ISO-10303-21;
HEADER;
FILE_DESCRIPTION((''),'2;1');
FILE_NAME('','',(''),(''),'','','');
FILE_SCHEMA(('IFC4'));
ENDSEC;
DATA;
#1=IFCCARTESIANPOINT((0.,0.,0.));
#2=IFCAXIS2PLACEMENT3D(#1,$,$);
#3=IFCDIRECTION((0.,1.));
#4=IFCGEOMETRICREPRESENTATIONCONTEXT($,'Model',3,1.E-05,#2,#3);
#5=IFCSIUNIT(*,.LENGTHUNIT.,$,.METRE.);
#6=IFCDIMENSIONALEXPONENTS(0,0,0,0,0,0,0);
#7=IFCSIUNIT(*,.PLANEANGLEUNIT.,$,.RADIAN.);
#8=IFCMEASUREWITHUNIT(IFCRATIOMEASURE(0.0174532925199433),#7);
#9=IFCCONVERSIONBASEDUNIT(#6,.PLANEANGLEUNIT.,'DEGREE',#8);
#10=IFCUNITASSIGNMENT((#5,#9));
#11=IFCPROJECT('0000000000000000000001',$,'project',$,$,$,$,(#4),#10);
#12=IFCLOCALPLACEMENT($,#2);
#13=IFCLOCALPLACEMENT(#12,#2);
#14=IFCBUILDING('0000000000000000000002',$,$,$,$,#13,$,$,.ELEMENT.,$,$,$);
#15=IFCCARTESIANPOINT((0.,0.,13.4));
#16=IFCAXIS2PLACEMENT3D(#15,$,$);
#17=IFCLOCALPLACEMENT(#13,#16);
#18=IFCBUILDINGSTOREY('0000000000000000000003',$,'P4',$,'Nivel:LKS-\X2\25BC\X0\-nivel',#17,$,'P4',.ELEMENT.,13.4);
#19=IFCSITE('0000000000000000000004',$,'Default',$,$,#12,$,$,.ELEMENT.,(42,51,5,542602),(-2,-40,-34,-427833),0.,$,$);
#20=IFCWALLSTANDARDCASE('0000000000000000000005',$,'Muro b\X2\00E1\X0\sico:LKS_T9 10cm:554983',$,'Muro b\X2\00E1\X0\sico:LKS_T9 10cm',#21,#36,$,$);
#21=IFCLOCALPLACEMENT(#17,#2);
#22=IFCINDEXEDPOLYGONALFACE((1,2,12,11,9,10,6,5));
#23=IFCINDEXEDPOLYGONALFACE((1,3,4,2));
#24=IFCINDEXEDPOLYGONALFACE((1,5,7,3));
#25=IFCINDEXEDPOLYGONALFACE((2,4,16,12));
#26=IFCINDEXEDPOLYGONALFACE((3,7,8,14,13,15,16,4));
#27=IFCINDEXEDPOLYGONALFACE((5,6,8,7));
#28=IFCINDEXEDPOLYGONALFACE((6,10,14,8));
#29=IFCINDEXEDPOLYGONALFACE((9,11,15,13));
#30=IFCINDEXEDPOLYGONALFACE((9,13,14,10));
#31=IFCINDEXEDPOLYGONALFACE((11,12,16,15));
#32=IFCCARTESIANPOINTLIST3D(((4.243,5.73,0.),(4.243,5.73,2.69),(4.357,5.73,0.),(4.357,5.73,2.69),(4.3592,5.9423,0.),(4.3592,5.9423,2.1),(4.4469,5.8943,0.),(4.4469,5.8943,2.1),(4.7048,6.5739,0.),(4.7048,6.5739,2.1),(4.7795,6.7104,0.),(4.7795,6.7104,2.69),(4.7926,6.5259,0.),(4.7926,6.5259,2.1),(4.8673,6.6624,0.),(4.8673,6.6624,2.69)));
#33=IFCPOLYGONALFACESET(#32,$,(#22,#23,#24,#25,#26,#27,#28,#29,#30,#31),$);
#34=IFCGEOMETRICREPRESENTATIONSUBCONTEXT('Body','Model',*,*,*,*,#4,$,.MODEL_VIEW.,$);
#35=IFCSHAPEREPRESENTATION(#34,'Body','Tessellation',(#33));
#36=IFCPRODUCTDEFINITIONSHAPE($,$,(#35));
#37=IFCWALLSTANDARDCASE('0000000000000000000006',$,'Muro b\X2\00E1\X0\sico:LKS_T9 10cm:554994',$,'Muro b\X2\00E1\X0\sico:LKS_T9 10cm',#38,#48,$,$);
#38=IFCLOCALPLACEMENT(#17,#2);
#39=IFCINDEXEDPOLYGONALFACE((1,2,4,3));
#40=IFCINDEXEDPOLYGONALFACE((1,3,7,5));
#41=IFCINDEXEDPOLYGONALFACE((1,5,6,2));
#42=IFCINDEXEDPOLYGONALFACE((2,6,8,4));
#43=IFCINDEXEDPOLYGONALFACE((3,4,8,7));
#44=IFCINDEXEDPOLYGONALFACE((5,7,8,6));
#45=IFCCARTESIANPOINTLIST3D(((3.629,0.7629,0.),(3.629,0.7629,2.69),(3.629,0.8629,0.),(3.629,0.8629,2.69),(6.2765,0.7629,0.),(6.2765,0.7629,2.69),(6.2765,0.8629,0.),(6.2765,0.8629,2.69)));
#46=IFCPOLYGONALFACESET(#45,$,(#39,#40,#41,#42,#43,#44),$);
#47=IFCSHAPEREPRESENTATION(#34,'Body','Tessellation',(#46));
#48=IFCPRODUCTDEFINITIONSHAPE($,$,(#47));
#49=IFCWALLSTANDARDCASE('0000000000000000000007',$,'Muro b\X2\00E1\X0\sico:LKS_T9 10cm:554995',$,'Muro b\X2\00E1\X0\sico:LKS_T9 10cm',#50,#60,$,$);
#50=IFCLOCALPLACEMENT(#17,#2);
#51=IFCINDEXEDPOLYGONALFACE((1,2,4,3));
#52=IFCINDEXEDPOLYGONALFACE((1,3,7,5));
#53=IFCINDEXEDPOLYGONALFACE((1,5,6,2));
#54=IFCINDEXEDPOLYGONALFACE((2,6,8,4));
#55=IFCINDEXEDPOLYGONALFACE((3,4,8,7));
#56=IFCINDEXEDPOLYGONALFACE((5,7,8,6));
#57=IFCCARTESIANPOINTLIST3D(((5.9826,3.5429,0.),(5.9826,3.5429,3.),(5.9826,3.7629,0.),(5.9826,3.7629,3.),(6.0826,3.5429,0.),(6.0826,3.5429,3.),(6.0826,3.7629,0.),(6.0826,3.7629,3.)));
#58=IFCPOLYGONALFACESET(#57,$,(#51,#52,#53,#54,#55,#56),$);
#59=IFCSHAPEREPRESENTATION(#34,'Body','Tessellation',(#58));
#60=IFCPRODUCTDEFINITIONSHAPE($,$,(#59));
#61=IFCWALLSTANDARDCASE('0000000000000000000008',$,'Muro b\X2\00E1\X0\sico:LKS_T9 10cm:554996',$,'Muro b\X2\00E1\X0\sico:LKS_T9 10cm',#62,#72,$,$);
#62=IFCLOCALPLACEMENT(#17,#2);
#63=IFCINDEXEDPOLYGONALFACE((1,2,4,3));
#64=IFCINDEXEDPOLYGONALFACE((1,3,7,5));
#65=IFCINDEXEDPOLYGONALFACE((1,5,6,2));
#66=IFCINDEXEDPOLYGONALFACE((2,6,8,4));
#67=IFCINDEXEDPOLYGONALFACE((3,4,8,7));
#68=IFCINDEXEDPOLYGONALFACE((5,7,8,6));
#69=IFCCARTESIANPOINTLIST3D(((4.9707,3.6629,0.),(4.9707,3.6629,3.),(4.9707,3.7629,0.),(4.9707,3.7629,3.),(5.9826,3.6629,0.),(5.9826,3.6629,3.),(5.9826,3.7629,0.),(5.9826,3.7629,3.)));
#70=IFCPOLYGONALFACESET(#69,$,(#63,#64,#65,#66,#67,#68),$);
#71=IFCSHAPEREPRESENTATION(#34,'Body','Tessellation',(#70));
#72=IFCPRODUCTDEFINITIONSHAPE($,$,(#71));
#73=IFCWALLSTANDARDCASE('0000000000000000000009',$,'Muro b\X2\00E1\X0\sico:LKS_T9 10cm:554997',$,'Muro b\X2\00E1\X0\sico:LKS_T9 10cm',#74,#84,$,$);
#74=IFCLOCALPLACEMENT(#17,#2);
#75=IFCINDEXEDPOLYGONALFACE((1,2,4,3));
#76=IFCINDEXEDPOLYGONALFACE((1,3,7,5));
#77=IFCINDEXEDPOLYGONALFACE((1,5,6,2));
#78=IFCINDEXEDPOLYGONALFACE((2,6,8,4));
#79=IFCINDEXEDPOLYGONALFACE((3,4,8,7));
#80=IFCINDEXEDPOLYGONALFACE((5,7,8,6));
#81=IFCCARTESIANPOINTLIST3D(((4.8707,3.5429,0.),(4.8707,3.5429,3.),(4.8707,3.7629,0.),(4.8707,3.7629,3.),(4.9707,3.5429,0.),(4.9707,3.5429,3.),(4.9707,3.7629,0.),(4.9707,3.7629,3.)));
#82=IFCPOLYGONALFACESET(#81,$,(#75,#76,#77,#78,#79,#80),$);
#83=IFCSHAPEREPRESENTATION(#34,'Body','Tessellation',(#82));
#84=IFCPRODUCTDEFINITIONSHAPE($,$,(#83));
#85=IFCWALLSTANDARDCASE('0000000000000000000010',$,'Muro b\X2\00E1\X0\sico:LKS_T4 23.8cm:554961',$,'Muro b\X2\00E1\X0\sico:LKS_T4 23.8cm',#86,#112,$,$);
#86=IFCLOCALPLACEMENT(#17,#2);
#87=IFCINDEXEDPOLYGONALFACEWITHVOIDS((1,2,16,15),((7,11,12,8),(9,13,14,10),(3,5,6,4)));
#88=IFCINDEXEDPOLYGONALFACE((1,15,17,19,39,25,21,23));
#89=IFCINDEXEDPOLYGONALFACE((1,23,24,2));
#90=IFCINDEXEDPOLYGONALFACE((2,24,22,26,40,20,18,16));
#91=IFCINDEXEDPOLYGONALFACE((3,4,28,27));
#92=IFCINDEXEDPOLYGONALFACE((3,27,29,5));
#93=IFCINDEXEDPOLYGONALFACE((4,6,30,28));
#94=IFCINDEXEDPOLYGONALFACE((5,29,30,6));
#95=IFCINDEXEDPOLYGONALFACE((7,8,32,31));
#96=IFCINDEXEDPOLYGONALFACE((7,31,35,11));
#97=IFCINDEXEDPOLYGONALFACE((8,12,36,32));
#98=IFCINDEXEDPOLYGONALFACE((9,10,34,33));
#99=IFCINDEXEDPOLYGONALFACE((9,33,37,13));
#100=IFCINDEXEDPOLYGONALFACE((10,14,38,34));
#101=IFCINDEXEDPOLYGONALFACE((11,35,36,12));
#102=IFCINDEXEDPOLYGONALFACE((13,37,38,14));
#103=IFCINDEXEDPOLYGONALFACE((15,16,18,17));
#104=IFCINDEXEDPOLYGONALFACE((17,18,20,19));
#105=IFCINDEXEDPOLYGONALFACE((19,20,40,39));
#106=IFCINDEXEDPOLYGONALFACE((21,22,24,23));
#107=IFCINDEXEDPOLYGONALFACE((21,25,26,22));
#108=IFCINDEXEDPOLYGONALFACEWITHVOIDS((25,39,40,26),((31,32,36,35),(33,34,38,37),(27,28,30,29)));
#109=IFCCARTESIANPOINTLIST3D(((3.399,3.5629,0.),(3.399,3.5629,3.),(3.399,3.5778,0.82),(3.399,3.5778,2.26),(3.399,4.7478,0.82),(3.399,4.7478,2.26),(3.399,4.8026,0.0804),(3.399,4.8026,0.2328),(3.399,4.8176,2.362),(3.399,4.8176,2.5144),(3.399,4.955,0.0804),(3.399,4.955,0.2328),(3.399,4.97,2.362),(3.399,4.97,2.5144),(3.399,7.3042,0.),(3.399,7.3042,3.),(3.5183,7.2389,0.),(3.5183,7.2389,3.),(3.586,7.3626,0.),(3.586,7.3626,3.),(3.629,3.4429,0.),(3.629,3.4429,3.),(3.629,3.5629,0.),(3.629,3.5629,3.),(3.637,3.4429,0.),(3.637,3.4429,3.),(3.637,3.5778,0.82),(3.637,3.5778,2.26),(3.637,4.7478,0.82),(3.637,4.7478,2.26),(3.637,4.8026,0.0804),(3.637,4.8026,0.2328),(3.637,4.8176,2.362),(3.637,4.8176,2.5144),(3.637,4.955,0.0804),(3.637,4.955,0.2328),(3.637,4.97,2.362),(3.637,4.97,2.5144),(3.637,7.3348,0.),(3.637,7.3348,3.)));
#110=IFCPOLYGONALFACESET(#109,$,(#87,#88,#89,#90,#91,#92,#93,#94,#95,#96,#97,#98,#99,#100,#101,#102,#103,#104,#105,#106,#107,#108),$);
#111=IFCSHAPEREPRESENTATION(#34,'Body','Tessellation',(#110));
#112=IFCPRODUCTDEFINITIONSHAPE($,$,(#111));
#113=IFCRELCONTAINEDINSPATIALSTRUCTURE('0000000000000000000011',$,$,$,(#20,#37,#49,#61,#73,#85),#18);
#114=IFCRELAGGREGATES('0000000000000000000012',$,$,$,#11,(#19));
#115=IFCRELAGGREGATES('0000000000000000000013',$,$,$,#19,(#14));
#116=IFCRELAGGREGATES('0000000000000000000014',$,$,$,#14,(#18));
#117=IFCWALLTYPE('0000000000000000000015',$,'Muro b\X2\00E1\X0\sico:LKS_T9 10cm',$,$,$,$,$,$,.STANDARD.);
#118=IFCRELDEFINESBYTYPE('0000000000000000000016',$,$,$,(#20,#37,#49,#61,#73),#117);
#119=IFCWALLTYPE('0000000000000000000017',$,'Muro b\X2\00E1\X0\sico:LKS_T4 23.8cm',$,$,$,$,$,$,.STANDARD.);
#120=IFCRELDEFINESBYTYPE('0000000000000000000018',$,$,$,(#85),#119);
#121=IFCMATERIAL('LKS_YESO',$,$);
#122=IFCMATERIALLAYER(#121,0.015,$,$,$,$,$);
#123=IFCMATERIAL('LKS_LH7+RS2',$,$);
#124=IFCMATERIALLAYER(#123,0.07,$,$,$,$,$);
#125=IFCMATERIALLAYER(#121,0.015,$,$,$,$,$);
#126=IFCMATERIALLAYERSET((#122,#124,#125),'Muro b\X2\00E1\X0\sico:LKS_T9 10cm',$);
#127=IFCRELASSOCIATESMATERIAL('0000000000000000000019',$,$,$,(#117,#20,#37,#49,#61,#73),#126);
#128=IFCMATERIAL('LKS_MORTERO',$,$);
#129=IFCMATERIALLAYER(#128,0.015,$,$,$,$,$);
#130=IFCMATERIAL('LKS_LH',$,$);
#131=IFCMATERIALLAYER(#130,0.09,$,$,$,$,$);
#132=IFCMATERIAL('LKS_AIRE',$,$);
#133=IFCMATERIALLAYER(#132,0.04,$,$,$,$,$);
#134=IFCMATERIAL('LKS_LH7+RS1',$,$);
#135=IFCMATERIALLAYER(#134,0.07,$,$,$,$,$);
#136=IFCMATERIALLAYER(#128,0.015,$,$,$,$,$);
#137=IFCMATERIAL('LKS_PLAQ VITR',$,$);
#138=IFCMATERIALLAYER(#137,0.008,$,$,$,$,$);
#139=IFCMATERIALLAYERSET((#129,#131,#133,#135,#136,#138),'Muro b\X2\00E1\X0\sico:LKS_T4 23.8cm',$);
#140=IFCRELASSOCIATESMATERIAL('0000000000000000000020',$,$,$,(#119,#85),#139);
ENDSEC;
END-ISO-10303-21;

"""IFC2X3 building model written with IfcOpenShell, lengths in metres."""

from ifc_helpers import new_model, entity, si_unit, converted_unit, direction, frame, frame_2d, origin, place, context, subcontext, project, spatial, polyline, rectangle, outline, extrude, clip, bounded_halfspace, material, layer, layer_set, layer_usage, type_object, element, save


model = new_model("IFC2X3")

# Units and contexts
model_context = context("Model", 3, precision=1e-05, world=origin(), true_north=direction((0.0, 1.0)))
body_context = subcontext(model_context, "Body", "Model", "MODEL_VIEW")
ifc_project = project(units=[si_unit("LENGTHUNIT", "METRE"), converted_unit("PLANEANGLEUNIT", "DEGREE", entity("IfcRatioMeasure", 0.0174532925199433), si_unit("PLANEANGLEUNIT", "RADIAN"), dimensions=[0, 0, 0, 0, 0, 0, 0])], contexts=[model_context])

# Site, building, storey
site_placement = place(None, origin())
site = spatial("IfcSite", under=ifc_project, at=site_placement, Name="Default", CompositionType="ELEMENT", RefLatitude=(42, 51, 5, 542602), RefLongitude=(-2, -40, -34, -427833), RefElevation=0.0)
building_placement = place(site_placement, origin())
building = spatial("IfcBuilding", under=site, at=building_placement, CompositionType="ELEMENT")
storey_placement = place(building_placement, frame((0.0, 0.0, 13.4)))
storey = spatial("IfcBuildingStorey", under=building, at=storey_placement, Name="P4", ObjectType="Nivel:LKS-▼-nivel", LongName="P4", CompositionType="ELEMENT", Elevation=13.4)

# Shared definitions
ifc_material_1 = material(Name="LKS_MORTERO")
ifc_material_2 = material(Name="LKS_PLAQ VITR")

# Shared definitions
ifc_material_3 = material(Name="LKS_LH")
ifc_material_4 = material(Name="LKS_AIRE")
ifc_material_5 = material(Name="LKS_LH7+RS1")
ifc_material_6 = material(Name="LKS_YESO")

# Shared definitions
ifc_layer_1 = layer(ifc_material_6, 0.015)
ifc_material_7 = material(Name="LKS_LH7+RS2")
ifc_layer_2 = layer(ifc_material_7, 0.07)
ifc_layer_3 = layer(ifc_material_6, 0.015)
ifc_layer_set_1 = layer_set([ifc_layer_1, ifc_layer_2, ifc_layer_3], Name="Muro básico:LKS_T9 10cm")
wall_type_1 = type_object("IfcWallType", Name="Muro básico:LKS_T9 10cm", PredefinedType="STANDARD", material=ifc_layer_set_1)

# Wall, opening
ifc_layer_usage_1 = layer_usage(ifc_layer_set_1, "AXIS2", "NEGATIVE", 0.05)
wall_1_placement = place(storey_placement, frame((4.2869, 5.706, 0.0), z_axis=(0.0, 0.0, 1.0), x_axis=(0.480022, 0.877256, 0.0)))
wall_1 = element("IfcWallStandardCase", 1, at=wall_1_placement, inside=storey, type_object=wall_type_1, material=ifc_layer_usage_1, Name="Muro básico:LKS_T9 10cm:554983", ObjectType="Muro básico:LKS_T9 10cm", context=body_context, shape_type="SweptSolid", body=[
    extrude(outline(polyline([(0.0547, -0.05), (1.1176, -0.05), (1.1176, 0.05), (0.0, 0.05), (0.0547, -0.05)])), origin(), (0.0, 0.0, 1.0), 2.69),
])
opening_1_placement = place(wall_1_placement, frame((0.962, 0.05, 0.0)))
element("IfcOpeningElement", 2, at=opening_1_placement, cuts=wall_1, ObjectType="Opening", context=body_context, shape_type="SweptSolid", body=[
    extrude(rectangle(XDim=2.1, YDim=0.72, at=frame_2d((1.05, 0.36), x_axis=(1.0, 0.0))), frame((0.0, 0.0, 0.0), z_axis=(0.0, -1.0, 0.0), x_axis=(0.0, 0.0, 1.0)), (0.0, 0.0, 1.0), 0.1),
])

# Walls
ifc_layer_usage_2 = layer_usage(ifc_layer_set_1, "AXIS2", "NEGATIVE", 0.05)
wall_2_placement = place(storey_placement, frame((6.2765, 0.8129, 0.0), z_axis=(0.0, 0.0, 1.0), x_axis=(-1.0, 0.0, 0.0)))
element("IfcWallStandardCase", 3, at=wall_2_placement, inside=storey, type_object=wall_type_1, material=ifc_layer_usage_2, Name="Muro básico:LKS_T9 10cm:554994", ObjectType="Muro básico:LKS_T9 10cm", context=body_context, shape_type="SweptSolid", body=[
    extrude(rectangle(XDim=2.6476, YDim=0.1, at=frame_2d((1.3238, 0.0), x_axis=(-1.0, 0.0))), origin(), (0.0, 0.0, 1.0), 2.69),
])
ifc_layer_usage_3 = layer_usage(ifc_layer_set_1, "AXIS2", "NEGATIVE", 0.05)
wall_3_placement = place(storey_placement, frame((6.0326, 3.5429, 0.0), z_axis=(0.0, 0.0, 1.0), x_axis=(0.0, 1.0, 0.0)))
element("IfcWallStandardCase", 4, at=wall_3_placement, inside=storey, type_object=wall_type_1, material=ifc_layer_usage_3, Name="Muro básico:LKS_T9 10cm:554995", ObjectType="Muro básico:LKS_T9 10cm", context=body_context, shape_type="SweptSolid", body=[
    extrude(rectangle(XDim=0.22, YDim=0.1, at=frame_2d((0.11, 0.0), x_axis=(-1.0, 0.0))), origin(), (0.0, 0.0, 1.0), 3.0),
])
ifc_layer_usage_4 = layer_usage(ifc_layer_set_1, "AXIS2", "NEGATIVE", 0.05)
wall_4_placement = place(storey_placement, frame((5.9826, 3.7129, 0.0), z_axis=(0.0, 0.0, 1.0), x_axis=(-1.0, 0.0, 0.0)))
element("IfcWallStandardCase", 5, at=wall_4_placement, inside=storey, type_object=wall_type_1, material=ifc_layer_usage_4, Name="Muro básico:LKS_T9 10cm:554996", ObjectType="Muro básico:LKS_T9 10cm", context=body_context, shape_type="SweptSolid", body=[
    extrude(rectangle(XDim=1.012, YDim=0.1, at=frame_2d((0.506, 0.0), x_axis=(-1.0, 0.0))), origin(), (0.0, 0.0, 1.0), 3.0),
])
ifc_layer_usage_5 = layer_usage(ifc_layer_set_1, "AXIS2", "NEGATIVE", 0.05)
wall_5_placement = place(storey_placement, frame((4.9207, 3.7629, 0.0), z_axis=(0.0, 0.0, 1.0), x_axis=(0.0, -1.0, 0.0)))
element("IfcWallStandardCase", 6, at=wall_5_placement, inside=storey, type_object=wall_type_1, material=ifc_layer_usage_5, Name="Muro básico:LKS_T9 10cm:554997", ObjectType="Muro básico:LKS_T9 10cm", context=body_context, shape_type="SweptSolid", body=[
    extrude(rectangle(XDim=0.22, YDim=0.1, at=frame_2d((0.11, 0.0), x_axis=(-1.0, 0.0))), origin(), (0.0, 0.0, 1.0), 3.0),
])

# Wall, openings
ifc_layer_4 = layer(ifc_material_1, 0.015)
ifc_layer_5 = layer(ifc_material_3, 0.09)
ifc_layer_6 = layer(ifc_material_4, 0.04)
ifc_layer_7 = layer(ifc_material_5, 0.07)
ifc_layer_8 = layer(ifc_material_1, 0.015)
ifc_layer_9 = layer(ifc_material_2, 0.008)
ifc_layer_set_2 = layer_set([ifc_layer_4, ifc_layer_5, ifc_layer_6, ifc_layer_7, ifc_layer_8, ifc_layer_9], Name="Muro básico:LKS_T4 23.8cm")
ifc_layer_usage_6 = layer_usage(ifc_layer_set_2, "AXIS2", "POSITIVE", -0.119)
wall_type_2 = type_object("IfcWallType", Name="Muro básico:LKS_T4 23.8cm", PredefinedType="STANDARD", material=ifc_layer_set_2)
wall_6_placement = place(storey_placement, frame((3.518, 7.3348, 0.0), z_axis=(0.0, 0.0, 1.0), x_axis=(0.0, -1.0, 0.0)))
wall_6 = element("IfcWallStandardCase", 7, at=wall_6_placement, inside=storey, type_object=wall_type_2, material=ifc_layer_usage_6, Name="Muro básico:LKS_T4 23.8cm:554961", ObjectType="Muro básico:LKS_T4 23.8cm", context=body_context, shape_type="Clipping", body=[
    clip(clip(clip(clip(extrude(outline(polyline([(0.0, 0.119), (-0.0279, 0.068), (0.0959, 0.0004), (0.0306, -0.119), (3.7719, -0.119), (3.7719, 0.111), (3.8919, 0.111), (3.8919, 0.119), (3.8419, 0.119), (3.7919, 0.119), (1.7048, 0.119), (1.6048, 0.119), (0.0, 0.119)])), origin(), (0.0, 0.0, 1.0), 3.0), bounded_halfspace(frame((3.7719, 0.111, 3.0), z_axis=(0.0, 1.0, 0.0), x_axis=(-1.0, 0.0, 0.0)), True, frame((3.7719, 0.111, 3.0), z_axis=(0.0, 1.0, 0.0), x_axis=(-1.0, 0.0, 0.0)), polyline([(0.0, 0.0), (-0.12, 0.0), (-0.12, -3.0), (0.0, -3.0), (0.0, 0.0)]))), bounded_halfspace(frame((3.7719, 0.111, 0.0), z_axis=(-1.0, 0.0, 0.0), x_axis=(0.0, 1.0, 0.0)), True, frame((3.7719, 0.111, 0.0), z_axis=(-1.0, 0.0, 0.0), x_axis=(0.0, 1.0, 0.0)), polyline([(0.0, 0.0), (-0.23, 0.0), (-0.23, -3.0), (0.0, -3.0), (0.0, 0.0)]))), bounded_halfspace(frame((0.0959, 0.0004, 0.0), z_axis=(0.479561, 0.877509, 0.0), x_axis=(0.0, 0.0, -1.0)), True, frame((0.0959, 0.0004, 0.0), z_axis=(0.479561, 0.877509, 0.0), x_axis=(0.0, 0.0, -1.0)), polyline([(0.0, 0.0), (0.0, 0.141), (-3.0, 0.141), (-3.0, 0.0), (-2.67, 0.0), (0.0, 0.0)]))), bounded_halfspace(frame((0.0959, 0.0004, 3.0), z_axis=(0.877509, -0.479561, 0.0), x_axis=(0.0, 0.0, -1.0)), True, frame((0.0959, 0.0004, 3.0), z_axis=(0.877509, -0.479561, 0.0), x_axis=(0.0, 0.0, -1.0)), polyline([(0.0, 0.0), (0.0, -0.0791), (0.0, -0.1361), (3.0, -0.1361), (3.0, 0.0), (0.33, 0.0), (0.0, 0.0)]))),
])
opening_2_placement = place(wall_6_placement, origin())
element("IfcOpeningElement", 8, at=opening_2_placement, cuts=wall_6, ObjectType="Opening", context=body_context, shape_type="SweptSolid", body=[
    extrude(rectangle(XDim=0.1524, YDim=0.1524, at=frame_2d((0.0, 0.0), x_axis=(0.0, 1.0))), frame((2.456, -1.405, 0.1566), z_axis=(0.0, 1.0, 0.0), x_axis=(-1.0, 0.0, 0.0)), (0.0, 0.0, 1.0), 3.048),
])
opening_3_placement = place(wall_6_placement, origin())
element("IfcOpeningElement", 9, at=opening_3_placement, cuts=wall_6, ObjectType="Opening", context=body_context, shape_type="SweptSolid", body=[
    extrude(rectangle(XDim=0.1524, YDim=0.1524, at=frame_2d((0.0, 0.0), x_axis=(0.0, 1.0))), frame((2.441, -1.405, 2.4382), z_axis=(0.0, 1.0, 0.0), x_axis=(-1.0, 0.0, 0.0)), (0.0, 0.0, 1.0), 3.048),
])
opening_4_placement = place(wall_6_placement, frame((2.587, -0.119, 0.82)))
element("IfcOpeningElement", 10, at=opening_4_placement, cuts=wall_6, ObjectType="Opening", context=body_context, shape_type="SweptSolid", body=[
    extrude(rectangle(XDim=1.44, YDim=1.17, at=frame_2d((0.72, 0.585), x_axis=(1.0, 0.0))), frame((0.0, 0.0, 0.0), z_axis=(0.0, 1.0, 0.0), x_axis=(0.0, 0.0, 1.0)), (0.0, 0.0, 1.0), 0.238),
])

save(model, "model.ifc")
